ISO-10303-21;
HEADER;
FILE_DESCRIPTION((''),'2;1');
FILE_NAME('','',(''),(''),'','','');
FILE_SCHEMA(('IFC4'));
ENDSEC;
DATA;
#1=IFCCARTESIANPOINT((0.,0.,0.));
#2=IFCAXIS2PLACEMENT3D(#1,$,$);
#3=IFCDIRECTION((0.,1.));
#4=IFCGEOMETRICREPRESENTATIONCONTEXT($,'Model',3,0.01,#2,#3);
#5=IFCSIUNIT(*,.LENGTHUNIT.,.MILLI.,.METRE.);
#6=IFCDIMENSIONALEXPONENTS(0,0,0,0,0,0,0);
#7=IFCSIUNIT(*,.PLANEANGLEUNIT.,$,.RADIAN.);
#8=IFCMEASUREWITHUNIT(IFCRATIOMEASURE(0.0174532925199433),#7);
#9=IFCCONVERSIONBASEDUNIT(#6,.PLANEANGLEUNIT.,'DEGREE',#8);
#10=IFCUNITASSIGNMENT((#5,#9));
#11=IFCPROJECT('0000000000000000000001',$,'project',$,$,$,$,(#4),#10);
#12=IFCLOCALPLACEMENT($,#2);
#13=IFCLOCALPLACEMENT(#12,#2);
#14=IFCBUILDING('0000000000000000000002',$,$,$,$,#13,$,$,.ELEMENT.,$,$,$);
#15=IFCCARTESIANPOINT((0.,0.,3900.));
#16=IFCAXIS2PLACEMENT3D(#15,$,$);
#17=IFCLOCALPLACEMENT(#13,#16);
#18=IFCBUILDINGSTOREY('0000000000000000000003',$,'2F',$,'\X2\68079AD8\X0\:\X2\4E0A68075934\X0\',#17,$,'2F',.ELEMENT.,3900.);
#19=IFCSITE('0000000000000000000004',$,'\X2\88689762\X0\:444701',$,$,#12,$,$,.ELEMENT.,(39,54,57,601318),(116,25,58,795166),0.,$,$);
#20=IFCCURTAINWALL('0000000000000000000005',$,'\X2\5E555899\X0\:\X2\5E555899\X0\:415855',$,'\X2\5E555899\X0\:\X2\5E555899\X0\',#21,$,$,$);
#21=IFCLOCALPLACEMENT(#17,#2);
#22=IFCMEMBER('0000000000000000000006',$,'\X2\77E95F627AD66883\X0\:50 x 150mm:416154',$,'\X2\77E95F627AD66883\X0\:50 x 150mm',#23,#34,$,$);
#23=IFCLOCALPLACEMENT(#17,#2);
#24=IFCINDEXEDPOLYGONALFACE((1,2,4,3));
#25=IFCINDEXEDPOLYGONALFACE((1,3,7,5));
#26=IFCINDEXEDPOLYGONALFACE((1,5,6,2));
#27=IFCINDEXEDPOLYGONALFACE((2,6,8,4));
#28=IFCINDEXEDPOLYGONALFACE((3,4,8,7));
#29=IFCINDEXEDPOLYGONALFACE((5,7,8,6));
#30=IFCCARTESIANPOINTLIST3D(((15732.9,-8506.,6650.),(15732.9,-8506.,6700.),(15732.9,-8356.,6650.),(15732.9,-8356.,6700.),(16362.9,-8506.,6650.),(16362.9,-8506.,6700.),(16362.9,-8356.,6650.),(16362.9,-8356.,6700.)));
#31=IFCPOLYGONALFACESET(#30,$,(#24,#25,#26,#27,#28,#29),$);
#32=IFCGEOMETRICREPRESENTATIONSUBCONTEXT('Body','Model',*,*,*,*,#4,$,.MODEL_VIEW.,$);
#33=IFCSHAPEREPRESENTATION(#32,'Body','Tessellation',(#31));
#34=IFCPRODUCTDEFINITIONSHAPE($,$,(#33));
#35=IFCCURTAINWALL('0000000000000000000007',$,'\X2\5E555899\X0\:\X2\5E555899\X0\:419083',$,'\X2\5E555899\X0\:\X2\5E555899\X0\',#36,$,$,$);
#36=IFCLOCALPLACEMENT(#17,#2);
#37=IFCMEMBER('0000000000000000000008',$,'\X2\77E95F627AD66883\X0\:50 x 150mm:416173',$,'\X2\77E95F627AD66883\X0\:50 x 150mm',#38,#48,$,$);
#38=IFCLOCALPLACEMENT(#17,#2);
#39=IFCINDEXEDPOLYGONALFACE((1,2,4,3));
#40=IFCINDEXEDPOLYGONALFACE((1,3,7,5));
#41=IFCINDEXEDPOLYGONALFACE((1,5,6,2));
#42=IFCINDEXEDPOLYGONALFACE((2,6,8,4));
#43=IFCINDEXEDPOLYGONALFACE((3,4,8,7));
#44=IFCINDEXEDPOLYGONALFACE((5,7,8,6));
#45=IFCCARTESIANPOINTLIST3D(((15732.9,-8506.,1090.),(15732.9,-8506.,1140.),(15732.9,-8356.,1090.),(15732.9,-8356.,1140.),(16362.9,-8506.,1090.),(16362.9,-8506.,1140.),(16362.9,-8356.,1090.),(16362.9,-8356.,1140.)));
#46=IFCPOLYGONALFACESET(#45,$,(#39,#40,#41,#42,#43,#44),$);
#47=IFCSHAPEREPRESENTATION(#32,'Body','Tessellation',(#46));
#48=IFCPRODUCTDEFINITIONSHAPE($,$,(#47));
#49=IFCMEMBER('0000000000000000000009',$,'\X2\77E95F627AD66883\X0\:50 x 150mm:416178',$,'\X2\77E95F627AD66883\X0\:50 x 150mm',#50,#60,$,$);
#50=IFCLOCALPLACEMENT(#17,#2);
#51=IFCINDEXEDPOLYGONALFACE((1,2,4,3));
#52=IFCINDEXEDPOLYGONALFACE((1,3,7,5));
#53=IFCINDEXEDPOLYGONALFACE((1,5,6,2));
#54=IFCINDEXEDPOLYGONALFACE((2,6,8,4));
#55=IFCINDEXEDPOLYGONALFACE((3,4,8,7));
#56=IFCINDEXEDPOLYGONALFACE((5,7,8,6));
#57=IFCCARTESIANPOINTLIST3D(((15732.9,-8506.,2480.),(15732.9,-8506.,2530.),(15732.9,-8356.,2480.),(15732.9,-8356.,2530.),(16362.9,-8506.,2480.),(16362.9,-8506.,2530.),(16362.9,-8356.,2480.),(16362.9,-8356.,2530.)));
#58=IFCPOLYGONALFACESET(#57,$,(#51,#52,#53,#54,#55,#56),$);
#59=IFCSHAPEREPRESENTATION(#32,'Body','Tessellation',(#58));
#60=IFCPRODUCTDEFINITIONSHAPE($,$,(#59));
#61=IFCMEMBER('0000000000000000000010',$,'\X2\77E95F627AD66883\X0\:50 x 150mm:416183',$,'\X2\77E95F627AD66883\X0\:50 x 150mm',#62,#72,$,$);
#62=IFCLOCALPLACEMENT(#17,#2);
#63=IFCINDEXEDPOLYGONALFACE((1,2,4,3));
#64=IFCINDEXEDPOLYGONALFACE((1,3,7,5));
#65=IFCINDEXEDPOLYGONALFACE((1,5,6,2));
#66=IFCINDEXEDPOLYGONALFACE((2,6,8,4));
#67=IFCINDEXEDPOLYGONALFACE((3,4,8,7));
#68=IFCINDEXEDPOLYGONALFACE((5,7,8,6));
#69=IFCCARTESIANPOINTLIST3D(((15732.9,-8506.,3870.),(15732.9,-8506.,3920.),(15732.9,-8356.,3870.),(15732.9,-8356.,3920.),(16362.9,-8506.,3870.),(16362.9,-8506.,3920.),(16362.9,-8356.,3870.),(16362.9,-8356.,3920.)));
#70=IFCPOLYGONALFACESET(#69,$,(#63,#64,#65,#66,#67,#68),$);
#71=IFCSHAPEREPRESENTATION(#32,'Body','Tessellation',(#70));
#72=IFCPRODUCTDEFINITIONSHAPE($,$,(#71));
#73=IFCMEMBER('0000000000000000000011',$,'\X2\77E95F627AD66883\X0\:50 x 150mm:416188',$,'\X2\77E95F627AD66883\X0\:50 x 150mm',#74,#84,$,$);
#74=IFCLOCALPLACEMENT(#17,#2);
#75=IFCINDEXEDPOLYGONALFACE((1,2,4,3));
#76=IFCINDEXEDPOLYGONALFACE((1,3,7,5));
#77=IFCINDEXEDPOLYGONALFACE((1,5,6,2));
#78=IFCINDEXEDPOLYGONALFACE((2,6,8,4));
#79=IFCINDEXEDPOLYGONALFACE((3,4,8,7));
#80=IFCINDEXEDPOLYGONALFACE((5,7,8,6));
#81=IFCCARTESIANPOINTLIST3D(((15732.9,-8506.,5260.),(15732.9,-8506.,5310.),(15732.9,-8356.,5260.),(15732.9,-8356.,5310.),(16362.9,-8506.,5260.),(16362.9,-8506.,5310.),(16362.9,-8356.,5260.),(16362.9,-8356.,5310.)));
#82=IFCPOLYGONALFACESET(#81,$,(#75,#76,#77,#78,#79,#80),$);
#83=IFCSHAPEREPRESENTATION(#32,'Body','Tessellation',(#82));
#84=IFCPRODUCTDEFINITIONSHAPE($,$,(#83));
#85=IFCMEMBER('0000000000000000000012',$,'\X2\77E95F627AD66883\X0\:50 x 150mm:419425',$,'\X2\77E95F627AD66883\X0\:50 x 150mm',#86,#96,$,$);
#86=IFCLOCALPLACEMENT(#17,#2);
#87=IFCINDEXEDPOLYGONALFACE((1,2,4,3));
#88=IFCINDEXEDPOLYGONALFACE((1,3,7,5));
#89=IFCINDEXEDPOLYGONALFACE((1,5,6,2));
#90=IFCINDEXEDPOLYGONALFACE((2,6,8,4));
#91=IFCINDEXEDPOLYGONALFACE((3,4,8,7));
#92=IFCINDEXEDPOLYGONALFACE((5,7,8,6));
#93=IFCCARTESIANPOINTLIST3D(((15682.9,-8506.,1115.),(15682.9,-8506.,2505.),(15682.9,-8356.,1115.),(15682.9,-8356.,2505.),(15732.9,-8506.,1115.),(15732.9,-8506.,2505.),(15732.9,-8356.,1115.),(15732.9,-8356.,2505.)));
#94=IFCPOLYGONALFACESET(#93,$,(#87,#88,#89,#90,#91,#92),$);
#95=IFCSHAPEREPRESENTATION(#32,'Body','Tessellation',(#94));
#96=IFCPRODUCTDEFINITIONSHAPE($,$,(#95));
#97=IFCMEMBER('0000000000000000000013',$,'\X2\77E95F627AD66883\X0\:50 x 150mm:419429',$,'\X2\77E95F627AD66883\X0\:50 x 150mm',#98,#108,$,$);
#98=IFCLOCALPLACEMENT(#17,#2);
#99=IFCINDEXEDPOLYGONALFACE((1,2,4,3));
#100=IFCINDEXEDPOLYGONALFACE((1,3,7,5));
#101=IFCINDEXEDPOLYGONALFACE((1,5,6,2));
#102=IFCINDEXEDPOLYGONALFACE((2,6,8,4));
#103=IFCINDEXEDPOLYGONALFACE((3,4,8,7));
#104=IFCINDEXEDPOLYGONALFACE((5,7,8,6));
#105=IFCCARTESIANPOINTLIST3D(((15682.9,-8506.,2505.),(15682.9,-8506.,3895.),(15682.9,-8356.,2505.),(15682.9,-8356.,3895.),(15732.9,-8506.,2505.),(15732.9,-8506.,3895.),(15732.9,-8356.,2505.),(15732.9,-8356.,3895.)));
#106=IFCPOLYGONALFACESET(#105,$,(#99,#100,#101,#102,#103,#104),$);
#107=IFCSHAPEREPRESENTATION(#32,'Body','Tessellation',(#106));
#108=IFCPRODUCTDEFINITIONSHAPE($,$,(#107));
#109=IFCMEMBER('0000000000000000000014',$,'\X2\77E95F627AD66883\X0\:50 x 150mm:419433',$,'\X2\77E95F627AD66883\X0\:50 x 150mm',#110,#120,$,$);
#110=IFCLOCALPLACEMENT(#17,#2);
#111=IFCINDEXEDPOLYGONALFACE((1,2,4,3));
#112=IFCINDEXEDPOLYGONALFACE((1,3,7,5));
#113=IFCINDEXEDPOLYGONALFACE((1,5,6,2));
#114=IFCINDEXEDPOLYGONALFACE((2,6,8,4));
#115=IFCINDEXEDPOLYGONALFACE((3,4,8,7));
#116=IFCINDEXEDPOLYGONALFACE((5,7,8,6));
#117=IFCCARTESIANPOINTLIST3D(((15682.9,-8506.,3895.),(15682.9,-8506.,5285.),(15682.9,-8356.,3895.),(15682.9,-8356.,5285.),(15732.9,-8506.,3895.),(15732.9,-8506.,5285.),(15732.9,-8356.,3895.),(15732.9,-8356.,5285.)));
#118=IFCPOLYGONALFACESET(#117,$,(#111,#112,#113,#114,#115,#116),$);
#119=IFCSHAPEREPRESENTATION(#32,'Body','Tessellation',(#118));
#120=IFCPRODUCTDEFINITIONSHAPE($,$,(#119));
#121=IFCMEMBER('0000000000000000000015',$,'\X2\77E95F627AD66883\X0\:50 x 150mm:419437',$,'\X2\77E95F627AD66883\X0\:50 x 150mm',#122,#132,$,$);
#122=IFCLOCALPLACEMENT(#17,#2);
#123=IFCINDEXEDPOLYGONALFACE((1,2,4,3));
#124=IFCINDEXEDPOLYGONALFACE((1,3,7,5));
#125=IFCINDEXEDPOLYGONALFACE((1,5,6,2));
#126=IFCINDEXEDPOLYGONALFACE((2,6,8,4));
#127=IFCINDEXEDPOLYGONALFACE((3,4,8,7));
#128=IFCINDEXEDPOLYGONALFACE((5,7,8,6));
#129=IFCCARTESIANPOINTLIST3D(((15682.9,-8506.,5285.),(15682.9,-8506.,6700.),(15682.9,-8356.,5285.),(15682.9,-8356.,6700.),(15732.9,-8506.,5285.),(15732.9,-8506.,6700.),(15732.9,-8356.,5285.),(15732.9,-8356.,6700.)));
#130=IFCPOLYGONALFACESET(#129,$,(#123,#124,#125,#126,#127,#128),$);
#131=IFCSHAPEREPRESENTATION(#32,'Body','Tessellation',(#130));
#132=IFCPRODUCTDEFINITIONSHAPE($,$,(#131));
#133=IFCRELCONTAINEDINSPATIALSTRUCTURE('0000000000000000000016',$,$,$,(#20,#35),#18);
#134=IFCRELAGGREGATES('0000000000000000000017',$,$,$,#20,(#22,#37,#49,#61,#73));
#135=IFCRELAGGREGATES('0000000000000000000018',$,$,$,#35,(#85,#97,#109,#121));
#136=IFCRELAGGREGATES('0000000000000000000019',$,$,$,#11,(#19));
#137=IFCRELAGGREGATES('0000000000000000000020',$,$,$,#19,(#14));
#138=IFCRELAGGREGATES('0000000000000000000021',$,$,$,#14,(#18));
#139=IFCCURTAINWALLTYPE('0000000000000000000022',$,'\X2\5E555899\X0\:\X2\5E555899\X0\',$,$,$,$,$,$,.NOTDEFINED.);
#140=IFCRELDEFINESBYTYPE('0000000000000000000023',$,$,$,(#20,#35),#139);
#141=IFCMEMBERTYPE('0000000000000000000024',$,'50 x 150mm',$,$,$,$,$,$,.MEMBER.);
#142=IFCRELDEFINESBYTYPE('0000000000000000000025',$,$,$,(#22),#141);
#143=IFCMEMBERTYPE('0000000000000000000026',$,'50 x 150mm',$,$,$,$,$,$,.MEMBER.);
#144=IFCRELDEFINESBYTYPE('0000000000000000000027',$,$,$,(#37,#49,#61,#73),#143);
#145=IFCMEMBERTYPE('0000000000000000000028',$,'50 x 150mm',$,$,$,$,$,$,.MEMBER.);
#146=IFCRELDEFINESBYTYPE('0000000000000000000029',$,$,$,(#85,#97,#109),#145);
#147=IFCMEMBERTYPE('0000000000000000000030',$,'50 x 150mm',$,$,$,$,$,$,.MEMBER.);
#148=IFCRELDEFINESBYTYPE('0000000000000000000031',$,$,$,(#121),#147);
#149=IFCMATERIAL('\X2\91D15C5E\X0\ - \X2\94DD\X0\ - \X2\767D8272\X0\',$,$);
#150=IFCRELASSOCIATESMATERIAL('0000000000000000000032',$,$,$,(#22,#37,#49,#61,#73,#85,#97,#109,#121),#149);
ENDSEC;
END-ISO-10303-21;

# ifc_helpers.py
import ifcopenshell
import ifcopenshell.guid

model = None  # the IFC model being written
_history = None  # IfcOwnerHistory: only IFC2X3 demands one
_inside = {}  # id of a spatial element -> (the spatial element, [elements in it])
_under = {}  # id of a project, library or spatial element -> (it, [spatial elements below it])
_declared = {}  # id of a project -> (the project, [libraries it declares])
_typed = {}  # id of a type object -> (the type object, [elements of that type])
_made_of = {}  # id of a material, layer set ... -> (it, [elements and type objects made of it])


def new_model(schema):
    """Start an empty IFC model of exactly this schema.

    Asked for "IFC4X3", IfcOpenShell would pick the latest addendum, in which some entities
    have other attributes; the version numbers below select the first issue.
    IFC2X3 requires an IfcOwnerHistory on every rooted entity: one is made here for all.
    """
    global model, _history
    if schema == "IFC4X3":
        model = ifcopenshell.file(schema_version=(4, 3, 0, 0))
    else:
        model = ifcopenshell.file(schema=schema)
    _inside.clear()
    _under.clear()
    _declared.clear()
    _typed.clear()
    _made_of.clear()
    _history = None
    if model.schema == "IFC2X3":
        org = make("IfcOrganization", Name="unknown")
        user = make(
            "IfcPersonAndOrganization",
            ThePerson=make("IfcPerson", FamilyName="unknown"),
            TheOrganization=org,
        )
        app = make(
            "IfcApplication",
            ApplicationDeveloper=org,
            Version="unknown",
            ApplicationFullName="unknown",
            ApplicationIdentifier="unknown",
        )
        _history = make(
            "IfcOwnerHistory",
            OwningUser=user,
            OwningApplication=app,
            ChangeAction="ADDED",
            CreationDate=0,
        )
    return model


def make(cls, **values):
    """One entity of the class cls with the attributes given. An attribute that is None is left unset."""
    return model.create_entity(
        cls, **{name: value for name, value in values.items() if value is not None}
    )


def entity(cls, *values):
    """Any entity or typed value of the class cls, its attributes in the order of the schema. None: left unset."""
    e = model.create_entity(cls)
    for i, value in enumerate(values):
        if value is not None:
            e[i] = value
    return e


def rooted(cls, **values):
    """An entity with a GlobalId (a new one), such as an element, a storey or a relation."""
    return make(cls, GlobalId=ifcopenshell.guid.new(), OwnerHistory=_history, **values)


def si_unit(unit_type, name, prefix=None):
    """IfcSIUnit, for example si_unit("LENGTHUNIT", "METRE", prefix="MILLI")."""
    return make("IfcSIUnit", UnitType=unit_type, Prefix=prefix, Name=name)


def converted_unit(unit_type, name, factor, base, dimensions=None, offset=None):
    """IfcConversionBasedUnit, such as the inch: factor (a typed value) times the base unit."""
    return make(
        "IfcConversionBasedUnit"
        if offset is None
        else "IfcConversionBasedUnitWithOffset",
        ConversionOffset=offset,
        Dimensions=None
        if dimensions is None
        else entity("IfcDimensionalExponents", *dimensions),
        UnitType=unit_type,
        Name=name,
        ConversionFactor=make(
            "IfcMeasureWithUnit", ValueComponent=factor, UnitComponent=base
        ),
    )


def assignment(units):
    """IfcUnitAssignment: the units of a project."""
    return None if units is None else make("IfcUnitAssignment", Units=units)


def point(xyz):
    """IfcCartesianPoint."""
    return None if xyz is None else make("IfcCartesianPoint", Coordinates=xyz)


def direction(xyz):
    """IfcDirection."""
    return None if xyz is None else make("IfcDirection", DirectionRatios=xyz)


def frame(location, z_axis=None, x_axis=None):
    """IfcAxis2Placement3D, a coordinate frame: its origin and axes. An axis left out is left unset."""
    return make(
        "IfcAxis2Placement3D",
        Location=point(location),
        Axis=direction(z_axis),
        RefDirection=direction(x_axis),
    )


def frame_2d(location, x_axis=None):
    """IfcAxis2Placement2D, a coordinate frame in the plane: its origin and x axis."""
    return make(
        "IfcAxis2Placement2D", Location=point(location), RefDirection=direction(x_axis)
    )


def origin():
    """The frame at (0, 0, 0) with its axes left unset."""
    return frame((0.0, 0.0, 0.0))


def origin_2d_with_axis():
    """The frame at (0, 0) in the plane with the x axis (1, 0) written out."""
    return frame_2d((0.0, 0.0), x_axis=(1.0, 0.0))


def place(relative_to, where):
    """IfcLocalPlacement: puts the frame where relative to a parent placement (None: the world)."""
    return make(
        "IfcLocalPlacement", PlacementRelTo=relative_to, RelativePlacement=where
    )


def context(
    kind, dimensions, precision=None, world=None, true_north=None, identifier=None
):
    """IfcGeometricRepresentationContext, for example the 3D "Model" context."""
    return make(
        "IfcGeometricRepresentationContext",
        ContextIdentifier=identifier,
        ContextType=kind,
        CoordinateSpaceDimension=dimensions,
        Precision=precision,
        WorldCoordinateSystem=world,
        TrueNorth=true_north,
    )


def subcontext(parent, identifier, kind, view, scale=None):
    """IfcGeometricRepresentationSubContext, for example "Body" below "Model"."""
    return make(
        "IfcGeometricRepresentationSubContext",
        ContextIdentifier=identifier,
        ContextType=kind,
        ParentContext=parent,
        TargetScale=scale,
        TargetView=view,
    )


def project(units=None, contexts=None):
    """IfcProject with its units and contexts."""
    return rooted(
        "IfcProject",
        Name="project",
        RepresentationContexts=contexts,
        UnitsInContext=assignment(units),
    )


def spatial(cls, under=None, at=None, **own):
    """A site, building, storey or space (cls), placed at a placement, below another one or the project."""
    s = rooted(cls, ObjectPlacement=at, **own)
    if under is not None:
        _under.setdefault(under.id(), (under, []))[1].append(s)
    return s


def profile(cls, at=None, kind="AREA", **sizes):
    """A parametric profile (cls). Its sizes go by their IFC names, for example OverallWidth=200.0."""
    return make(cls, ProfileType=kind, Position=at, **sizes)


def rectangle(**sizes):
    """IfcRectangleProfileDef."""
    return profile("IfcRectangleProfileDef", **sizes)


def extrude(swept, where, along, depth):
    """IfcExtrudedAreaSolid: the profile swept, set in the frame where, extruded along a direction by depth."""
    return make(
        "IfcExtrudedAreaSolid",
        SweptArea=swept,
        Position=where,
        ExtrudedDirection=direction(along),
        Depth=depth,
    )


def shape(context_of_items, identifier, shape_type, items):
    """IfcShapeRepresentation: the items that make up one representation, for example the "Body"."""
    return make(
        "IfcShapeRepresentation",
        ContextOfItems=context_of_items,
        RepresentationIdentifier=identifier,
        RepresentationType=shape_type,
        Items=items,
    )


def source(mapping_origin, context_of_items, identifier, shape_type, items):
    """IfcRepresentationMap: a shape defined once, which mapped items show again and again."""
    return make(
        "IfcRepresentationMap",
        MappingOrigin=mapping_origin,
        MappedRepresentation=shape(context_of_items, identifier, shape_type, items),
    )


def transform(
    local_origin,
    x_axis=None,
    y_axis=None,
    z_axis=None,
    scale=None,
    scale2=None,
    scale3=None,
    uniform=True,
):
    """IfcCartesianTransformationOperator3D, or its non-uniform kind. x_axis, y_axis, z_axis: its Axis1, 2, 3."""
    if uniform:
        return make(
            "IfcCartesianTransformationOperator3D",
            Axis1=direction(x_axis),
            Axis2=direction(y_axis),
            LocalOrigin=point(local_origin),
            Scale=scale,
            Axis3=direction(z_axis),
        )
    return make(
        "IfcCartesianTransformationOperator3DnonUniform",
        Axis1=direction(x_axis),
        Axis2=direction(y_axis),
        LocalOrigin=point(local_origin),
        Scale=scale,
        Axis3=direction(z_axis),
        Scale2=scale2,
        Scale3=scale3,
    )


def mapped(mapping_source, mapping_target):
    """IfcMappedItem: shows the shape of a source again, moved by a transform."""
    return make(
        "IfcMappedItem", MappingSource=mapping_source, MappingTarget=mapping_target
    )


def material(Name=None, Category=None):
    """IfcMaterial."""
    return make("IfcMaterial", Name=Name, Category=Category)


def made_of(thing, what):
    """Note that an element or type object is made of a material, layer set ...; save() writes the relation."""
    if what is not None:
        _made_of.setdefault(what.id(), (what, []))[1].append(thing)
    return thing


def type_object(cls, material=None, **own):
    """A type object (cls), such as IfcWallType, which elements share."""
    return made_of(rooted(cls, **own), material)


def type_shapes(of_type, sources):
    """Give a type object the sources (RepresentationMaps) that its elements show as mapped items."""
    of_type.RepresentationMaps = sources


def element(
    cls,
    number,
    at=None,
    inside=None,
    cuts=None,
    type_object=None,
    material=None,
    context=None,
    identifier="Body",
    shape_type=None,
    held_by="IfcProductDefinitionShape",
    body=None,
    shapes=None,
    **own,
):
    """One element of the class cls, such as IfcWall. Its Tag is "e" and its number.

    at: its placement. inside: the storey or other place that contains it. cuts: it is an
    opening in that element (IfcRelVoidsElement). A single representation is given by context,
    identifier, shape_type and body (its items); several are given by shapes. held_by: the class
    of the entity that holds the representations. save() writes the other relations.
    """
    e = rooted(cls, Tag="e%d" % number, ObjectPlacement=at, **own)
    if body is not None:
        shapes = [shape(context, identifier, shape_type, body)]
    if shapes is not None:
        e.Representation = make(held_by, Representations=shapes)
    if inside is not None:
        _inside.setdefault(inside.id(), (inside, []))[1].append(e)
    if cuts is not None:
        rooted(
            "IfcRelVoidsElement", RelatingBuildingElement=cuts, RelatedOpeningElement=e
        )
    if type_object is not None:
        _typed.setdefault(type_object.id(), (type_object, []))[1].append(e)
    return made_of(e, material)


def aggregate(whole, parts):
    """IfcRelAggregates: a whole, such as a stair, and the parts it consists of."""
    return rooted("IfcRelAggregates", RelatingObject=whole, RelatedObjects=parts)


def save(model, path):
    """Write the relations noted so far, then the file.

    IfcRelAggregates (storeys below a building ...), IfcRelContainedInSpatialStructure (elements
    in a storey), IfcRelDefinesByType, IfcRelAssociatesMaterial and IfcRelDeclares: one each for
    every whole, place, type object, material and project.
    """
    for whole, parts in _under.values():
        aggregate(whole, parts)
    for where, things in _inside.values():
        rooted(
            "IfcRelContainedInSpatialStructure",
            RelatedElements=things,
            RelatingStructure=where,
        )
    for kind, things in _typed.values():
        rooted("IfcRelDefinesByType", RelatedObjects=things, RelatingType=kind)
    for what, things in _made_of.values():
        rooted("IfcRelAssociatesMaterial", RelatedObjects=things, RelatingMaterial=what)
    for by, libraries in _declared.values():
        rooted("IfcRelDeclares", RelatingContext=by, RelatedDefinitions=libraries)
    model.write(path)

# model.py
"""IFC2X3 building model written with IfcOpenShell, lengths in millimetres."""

from ifc_helpers import new_model, entity, si_unit, converted_unit, direction, frame, origin, origin_2d_with_axis, place, context, subcontext, project, spatial, rectangle, extrude, source, transform, mapped, material, type_object, type_shapes, element, aggregate, save


model = new_model("IFC2X3")

# Units and contexts
model_context = context("Model", 3, precision=0.01, world=origin(), true_north=direction((0.0, 1.0)))
body_context = subcontext(model_context, "Body", "Model", "MODEL_VIEW")
ifc_project = project(units=[si_unit("LENGTHUNIT", "METRE", prefix="MILLI"), converted_unit("PLANEANGLEUNIT", "DEGREE", entity("IfcRatioMeasure", 0.0174532925199433), si_unit("PLANEANGLEUNIT", "RADIAN"), dimensions=[0, 0, 0, 0, 0, 0, 0])], contexts=[model_context])

# Site, building, storey
site_placement = place(None, origin())
site = spatial("IfcSite", under=ifc_project, at=site_placement, Name="表面:444701", CompositionType="ELEMENT", RefLatitude=(39, 54, 57, 601318), RefLongitude=(116, 25, 58, 795166), RefElevation=0.0)
building_placement = place(site_placement, origin())
building = spatial("IfcBuilding", under=site, at=building_placement, CompositionType="ELEMENT")
storey_placement = place(building_placement, frame((0.0, 0.0, 3900.0)))
storey = spatial("IfcBuildingStorey", under=building, at=storey_placement, Name="2F", ObjectType="标高:上标头", LongName="2F", CompositionType="ELEMENT", Elevation=3900.0)

# Curtain walls, member
curtain_wall_type = type_object("IfcCurtainWallType", Name="幕墙:幕墙", PredefinedType="NOTDEFINED")
curtain_wall_1_placement = place(storey_placement, frame((0.0, 0.0, -3900.0)))
curtain_wall_1 = element("IfcCurtainWall", 1, at=curtain_wall_1_placement, inside=storey, type_object=curtain_wall_type, Name="幕墙:幕墙:415855", ObjectType="幕墙:幕墙")
ifc_material_1 = material(Name="金属 - 铝 - 白色")
member_type_1 = type_object("IfcMemberType", Name="50 x 150mm", PredefinedType="MEMBER")
shared_shape_1 = source(origin(), body_context, "Body", "SweptSolid", [
    extrude(rectangle(XDim=150.0, YDim=50.0, at=origin_2d_with_axis()), frame((-25.0, 0.0, -630.0), z_axis=(0.0, 0.0, 1.0), x_axis=(0.0, -1.0, 0.0)), (0.0, 0.0, 1.0), 630.0),
])
type_shapes(member_type_1, [shared_shape_1])
member_1_placement = place(storey_placement, frame((15732.9, -8431.0, 6700.0), z_axis=(-1.0, 0.0, 0.0), x_axis=(0.0, 0.0, 1.0)))
member_1 = element("IfcMember", 2, at=member_1_placement, type_object=member_type_1, material=ifc_material_1, Name="矩形竖梃:50 x 150mm:416154", ObjectType="矩形竖梃:50 x 150mm", context=body_context, shape_type="MappedRepresentation", body=[
    mapped(shared_shape_1, transform((0.0, 0.0, 0.0), scale=1.0)),
])
curtain_wall_2_placement = place(storey_placement, frame((0.0, 0.0, -3900.0)))
curtain_wall_2 = element("IfcCurtainWall", 3, at=curtain_wall_2_placement, inside=storey, type_object=curtain_wall_type, Name="幕墙:幕墙:419083", ObjectType="幕墙:幕墙")

# Members
member_type_2 = type_object("IfcMemberType", Name="50 x 150mm", PredefinedType="MEMBER")
shared_shape_2 = source(origin(), body_context, "Body", "SweptSolid", [
    extrude(rectangle(XDim=150.0, YDim=50.0, at=origin_2d_with_axis()), frame((0.0, 0.0, -630.0), z_axis=(0.0, 0.0, 1.0), x_axis=(0.0, -1.0, 0.0)), (0.0, 0.0, 1.0), 630.0),
])
type_shapes(member_type_2, [shared_shape_2])
member_2_placement = place(storey_placement, frame((15732.9, -8431.0, 1115.0), z_axis=(-1.0, 0.0, 0.0), x_axis=(0.0, 0.0, 1.0)))
member_2 = element("IfcMember", 4, at=member_2_placement, type_object=member_type_2, material=ifc_material_1, Name="矩形竖梃:50 x 150mm:416173", ObjectType="矩形竖梃:50 x 150mm", context=body_context, shape_type="MappedRepresentation", body=[
    mapped(shared_shape_2, transform((0.0, 0.0, 0.0), scale=1.0)),
])
member_3_placement = place(storey_placement, frame((15732.9, -8431.0, 2505.0), z_axis=(-1.0, 0.0, 0.0), x_axis=(0.0, 0.0, 1.0)))
member_3 = element("IfcMember", 5, at=member_3_placement, type_object=member_type_2, material=ifc_material_1, Name="矩形竖梃:50 x 150mm:416178", ObjectType="矩形竖梃:50 x 150mm", context=body_context, shape_type="MappedRepresentation", body=[
    mapped(shared_shape_2, transform((0.0, 0.0, 0.0), scale=1.0)),
])
member_4_placement = place(storey_placement, frame((15732.9, -8431.0, 3895.0), z_axis=(-1.0, 0.0, 0.0), x_axis=(0.0, 0.0, 1.0)))
member_4 = element("IfcMember", 6, at=member_4_placement, type_object=member_type_2, material=ifc_material_1, Name="矩形竖梃:50 x 150mm:416183", ObjectType="矩形竖梃:50 x 150mm", context=body_context, shape_type="MappedRepresentation", body=[
    mapped(shared_shape_2, transform((0.0, 0.0, 0.0), scale=1.0)),
])
member_5_placement = place(storey_placement, frame((15732.9, -8431.0, 5285.0), z_axis=(-1.0, 0.0, 0.0), x_axis=(0.0, 0.0, 1.0)))
member_5 = element("IfcMember", 7, at=member_5_placement, type_object=member_type_2, material=ifc_material_1, Name="矩形竖梃:50 x 150mm:416188", ObjectType="矩形竖梃:50 x 150mm", context=body_context, shape_type="MappedRepresentation", body=[
    mapped(shared_shape_2, transform((0.0, 0.0, 0.0), scale=1.0)),
])
member_type_3 = type_object("IfcMemberType", Name="50 x 150mm", PredefinedType="MEMBER")
shared_shape_3 = source(origin(), body_context, "Body", "SweptSolid", [
    extrude(rectangle(XDim=150.0, YDim=50.0, at=origin_2d_with_axis()), frame((0.0, 0.0, -1390.0), z_axis=(0.0, 0.0, 1.0), x_axis=(0.0, -1.0, 0.0)), (0.0, 0.0, 1.0), 1390.0),
])
type_shapes(member_type_3, [shared_shape_3])
member_6_placement = place(storey_placement, frame((15707.9, -8431.0, 1115.0), z_axis=(0.0, 0.0, -1.0), x_axis=(-1.0, 0.0, 0.0)))
member_6 = element("IfcMember", 8, at=member_6_placement, type_object=member_type_3, material=ifc_material_1, Name="矩形竖梃:50 x 150mm:419425", ObjectType="矩形竖梃:50 x 150mm", context=body_context, shape_type="MappedRepresentation", body=[
    mapped(shared_shape_3, transform((0.0, 0.0, 0.0), scale=1.0)),
])
member_7_placement = place(storey_placement, frame((15707.9, -8431.0, 2505.0), z_axis=(0.0, 0.0, -1.0), x_axis=(-1.0, 0.0, 0.0)))
member_7 = element("IfcMember", 9, at=member_7_placement, type_object=member_type_3, material=ifc_material_1, Name="矩形竖梃:50 x 150mm:419429", ObjectType="矩形竖梃:50 x 150mm", context=body_context, shape_type="MappedRepresentation", body=[
    mapped(shared_shape_3, transform((0.0, 0.0, 0.0), scale=1.0)),
])
member_8_placement = place(storey_placement, frame((15707.9, -8431.0, 3895.0), z_axis=(0.0, 0.0, -1.0), x_axis=(-1.0, 0.0, 0.0)))
member_8 = element("IfcMember", 10, at=member_8_placement, type_object=member_type_3, material=ifc_material_1, Name="矩形竖梃:50 x 150mm:419433", ObjectType="矩形竖梃:50 x 150mm", context=body_context, shape_type="MappedRepresentation", body=[
    mapped(shared_shape_3, transform((0.0, 0.0, 0.0), scale=1.0)),
])
member_type_4 = type_object("IfcMemberType", Name="50 x 150mm", PredefinedType="MEMBER")
shared_shape_4 = source(origin(), body_context, "Body", "SweptSolid", [
    extrude(rectangle(XDim=150.0, YDim=50.0, at=origin_2d_with_axis()), frame((0.0, 0.0, -1415.0), z_axis=(0.0, 0.0, 1.0), x_axis=(0.0, -1.0, 0.0)), (0.0, 0.0, 1.0), 1415.0),
])
type_shapes(member_type_4, [shared_shape_4])
member_9_placement = place(storey_placement, frame((15707.9, -8431.0, 5285.0), z_axis=(0.0, 0.0, -1.0), x_axis=(-1.0, 0.0, 0.0)))
member_9 = element("IfcMember", 11, at=member_9_placement, type_object=member_type_4, material=ifc_material_1, Name="矩形竖梃:50 x 150mm:419437", ObjectType="矩形竖梃:50 x 150mm", context=body_context, shape_type="MappedRepresentation", body=[
    mapped(shared_shape_4, transform((0.0, 0.0, 0.0), scale=1.0)),
])

aggregate(curtain_wall_1, [member_1, member_2, member_3, member_4, member_5])
aggregate(curtain_wall_2, [member_6, member_7, member_8, member_9])

save(model, "model.ifc")
